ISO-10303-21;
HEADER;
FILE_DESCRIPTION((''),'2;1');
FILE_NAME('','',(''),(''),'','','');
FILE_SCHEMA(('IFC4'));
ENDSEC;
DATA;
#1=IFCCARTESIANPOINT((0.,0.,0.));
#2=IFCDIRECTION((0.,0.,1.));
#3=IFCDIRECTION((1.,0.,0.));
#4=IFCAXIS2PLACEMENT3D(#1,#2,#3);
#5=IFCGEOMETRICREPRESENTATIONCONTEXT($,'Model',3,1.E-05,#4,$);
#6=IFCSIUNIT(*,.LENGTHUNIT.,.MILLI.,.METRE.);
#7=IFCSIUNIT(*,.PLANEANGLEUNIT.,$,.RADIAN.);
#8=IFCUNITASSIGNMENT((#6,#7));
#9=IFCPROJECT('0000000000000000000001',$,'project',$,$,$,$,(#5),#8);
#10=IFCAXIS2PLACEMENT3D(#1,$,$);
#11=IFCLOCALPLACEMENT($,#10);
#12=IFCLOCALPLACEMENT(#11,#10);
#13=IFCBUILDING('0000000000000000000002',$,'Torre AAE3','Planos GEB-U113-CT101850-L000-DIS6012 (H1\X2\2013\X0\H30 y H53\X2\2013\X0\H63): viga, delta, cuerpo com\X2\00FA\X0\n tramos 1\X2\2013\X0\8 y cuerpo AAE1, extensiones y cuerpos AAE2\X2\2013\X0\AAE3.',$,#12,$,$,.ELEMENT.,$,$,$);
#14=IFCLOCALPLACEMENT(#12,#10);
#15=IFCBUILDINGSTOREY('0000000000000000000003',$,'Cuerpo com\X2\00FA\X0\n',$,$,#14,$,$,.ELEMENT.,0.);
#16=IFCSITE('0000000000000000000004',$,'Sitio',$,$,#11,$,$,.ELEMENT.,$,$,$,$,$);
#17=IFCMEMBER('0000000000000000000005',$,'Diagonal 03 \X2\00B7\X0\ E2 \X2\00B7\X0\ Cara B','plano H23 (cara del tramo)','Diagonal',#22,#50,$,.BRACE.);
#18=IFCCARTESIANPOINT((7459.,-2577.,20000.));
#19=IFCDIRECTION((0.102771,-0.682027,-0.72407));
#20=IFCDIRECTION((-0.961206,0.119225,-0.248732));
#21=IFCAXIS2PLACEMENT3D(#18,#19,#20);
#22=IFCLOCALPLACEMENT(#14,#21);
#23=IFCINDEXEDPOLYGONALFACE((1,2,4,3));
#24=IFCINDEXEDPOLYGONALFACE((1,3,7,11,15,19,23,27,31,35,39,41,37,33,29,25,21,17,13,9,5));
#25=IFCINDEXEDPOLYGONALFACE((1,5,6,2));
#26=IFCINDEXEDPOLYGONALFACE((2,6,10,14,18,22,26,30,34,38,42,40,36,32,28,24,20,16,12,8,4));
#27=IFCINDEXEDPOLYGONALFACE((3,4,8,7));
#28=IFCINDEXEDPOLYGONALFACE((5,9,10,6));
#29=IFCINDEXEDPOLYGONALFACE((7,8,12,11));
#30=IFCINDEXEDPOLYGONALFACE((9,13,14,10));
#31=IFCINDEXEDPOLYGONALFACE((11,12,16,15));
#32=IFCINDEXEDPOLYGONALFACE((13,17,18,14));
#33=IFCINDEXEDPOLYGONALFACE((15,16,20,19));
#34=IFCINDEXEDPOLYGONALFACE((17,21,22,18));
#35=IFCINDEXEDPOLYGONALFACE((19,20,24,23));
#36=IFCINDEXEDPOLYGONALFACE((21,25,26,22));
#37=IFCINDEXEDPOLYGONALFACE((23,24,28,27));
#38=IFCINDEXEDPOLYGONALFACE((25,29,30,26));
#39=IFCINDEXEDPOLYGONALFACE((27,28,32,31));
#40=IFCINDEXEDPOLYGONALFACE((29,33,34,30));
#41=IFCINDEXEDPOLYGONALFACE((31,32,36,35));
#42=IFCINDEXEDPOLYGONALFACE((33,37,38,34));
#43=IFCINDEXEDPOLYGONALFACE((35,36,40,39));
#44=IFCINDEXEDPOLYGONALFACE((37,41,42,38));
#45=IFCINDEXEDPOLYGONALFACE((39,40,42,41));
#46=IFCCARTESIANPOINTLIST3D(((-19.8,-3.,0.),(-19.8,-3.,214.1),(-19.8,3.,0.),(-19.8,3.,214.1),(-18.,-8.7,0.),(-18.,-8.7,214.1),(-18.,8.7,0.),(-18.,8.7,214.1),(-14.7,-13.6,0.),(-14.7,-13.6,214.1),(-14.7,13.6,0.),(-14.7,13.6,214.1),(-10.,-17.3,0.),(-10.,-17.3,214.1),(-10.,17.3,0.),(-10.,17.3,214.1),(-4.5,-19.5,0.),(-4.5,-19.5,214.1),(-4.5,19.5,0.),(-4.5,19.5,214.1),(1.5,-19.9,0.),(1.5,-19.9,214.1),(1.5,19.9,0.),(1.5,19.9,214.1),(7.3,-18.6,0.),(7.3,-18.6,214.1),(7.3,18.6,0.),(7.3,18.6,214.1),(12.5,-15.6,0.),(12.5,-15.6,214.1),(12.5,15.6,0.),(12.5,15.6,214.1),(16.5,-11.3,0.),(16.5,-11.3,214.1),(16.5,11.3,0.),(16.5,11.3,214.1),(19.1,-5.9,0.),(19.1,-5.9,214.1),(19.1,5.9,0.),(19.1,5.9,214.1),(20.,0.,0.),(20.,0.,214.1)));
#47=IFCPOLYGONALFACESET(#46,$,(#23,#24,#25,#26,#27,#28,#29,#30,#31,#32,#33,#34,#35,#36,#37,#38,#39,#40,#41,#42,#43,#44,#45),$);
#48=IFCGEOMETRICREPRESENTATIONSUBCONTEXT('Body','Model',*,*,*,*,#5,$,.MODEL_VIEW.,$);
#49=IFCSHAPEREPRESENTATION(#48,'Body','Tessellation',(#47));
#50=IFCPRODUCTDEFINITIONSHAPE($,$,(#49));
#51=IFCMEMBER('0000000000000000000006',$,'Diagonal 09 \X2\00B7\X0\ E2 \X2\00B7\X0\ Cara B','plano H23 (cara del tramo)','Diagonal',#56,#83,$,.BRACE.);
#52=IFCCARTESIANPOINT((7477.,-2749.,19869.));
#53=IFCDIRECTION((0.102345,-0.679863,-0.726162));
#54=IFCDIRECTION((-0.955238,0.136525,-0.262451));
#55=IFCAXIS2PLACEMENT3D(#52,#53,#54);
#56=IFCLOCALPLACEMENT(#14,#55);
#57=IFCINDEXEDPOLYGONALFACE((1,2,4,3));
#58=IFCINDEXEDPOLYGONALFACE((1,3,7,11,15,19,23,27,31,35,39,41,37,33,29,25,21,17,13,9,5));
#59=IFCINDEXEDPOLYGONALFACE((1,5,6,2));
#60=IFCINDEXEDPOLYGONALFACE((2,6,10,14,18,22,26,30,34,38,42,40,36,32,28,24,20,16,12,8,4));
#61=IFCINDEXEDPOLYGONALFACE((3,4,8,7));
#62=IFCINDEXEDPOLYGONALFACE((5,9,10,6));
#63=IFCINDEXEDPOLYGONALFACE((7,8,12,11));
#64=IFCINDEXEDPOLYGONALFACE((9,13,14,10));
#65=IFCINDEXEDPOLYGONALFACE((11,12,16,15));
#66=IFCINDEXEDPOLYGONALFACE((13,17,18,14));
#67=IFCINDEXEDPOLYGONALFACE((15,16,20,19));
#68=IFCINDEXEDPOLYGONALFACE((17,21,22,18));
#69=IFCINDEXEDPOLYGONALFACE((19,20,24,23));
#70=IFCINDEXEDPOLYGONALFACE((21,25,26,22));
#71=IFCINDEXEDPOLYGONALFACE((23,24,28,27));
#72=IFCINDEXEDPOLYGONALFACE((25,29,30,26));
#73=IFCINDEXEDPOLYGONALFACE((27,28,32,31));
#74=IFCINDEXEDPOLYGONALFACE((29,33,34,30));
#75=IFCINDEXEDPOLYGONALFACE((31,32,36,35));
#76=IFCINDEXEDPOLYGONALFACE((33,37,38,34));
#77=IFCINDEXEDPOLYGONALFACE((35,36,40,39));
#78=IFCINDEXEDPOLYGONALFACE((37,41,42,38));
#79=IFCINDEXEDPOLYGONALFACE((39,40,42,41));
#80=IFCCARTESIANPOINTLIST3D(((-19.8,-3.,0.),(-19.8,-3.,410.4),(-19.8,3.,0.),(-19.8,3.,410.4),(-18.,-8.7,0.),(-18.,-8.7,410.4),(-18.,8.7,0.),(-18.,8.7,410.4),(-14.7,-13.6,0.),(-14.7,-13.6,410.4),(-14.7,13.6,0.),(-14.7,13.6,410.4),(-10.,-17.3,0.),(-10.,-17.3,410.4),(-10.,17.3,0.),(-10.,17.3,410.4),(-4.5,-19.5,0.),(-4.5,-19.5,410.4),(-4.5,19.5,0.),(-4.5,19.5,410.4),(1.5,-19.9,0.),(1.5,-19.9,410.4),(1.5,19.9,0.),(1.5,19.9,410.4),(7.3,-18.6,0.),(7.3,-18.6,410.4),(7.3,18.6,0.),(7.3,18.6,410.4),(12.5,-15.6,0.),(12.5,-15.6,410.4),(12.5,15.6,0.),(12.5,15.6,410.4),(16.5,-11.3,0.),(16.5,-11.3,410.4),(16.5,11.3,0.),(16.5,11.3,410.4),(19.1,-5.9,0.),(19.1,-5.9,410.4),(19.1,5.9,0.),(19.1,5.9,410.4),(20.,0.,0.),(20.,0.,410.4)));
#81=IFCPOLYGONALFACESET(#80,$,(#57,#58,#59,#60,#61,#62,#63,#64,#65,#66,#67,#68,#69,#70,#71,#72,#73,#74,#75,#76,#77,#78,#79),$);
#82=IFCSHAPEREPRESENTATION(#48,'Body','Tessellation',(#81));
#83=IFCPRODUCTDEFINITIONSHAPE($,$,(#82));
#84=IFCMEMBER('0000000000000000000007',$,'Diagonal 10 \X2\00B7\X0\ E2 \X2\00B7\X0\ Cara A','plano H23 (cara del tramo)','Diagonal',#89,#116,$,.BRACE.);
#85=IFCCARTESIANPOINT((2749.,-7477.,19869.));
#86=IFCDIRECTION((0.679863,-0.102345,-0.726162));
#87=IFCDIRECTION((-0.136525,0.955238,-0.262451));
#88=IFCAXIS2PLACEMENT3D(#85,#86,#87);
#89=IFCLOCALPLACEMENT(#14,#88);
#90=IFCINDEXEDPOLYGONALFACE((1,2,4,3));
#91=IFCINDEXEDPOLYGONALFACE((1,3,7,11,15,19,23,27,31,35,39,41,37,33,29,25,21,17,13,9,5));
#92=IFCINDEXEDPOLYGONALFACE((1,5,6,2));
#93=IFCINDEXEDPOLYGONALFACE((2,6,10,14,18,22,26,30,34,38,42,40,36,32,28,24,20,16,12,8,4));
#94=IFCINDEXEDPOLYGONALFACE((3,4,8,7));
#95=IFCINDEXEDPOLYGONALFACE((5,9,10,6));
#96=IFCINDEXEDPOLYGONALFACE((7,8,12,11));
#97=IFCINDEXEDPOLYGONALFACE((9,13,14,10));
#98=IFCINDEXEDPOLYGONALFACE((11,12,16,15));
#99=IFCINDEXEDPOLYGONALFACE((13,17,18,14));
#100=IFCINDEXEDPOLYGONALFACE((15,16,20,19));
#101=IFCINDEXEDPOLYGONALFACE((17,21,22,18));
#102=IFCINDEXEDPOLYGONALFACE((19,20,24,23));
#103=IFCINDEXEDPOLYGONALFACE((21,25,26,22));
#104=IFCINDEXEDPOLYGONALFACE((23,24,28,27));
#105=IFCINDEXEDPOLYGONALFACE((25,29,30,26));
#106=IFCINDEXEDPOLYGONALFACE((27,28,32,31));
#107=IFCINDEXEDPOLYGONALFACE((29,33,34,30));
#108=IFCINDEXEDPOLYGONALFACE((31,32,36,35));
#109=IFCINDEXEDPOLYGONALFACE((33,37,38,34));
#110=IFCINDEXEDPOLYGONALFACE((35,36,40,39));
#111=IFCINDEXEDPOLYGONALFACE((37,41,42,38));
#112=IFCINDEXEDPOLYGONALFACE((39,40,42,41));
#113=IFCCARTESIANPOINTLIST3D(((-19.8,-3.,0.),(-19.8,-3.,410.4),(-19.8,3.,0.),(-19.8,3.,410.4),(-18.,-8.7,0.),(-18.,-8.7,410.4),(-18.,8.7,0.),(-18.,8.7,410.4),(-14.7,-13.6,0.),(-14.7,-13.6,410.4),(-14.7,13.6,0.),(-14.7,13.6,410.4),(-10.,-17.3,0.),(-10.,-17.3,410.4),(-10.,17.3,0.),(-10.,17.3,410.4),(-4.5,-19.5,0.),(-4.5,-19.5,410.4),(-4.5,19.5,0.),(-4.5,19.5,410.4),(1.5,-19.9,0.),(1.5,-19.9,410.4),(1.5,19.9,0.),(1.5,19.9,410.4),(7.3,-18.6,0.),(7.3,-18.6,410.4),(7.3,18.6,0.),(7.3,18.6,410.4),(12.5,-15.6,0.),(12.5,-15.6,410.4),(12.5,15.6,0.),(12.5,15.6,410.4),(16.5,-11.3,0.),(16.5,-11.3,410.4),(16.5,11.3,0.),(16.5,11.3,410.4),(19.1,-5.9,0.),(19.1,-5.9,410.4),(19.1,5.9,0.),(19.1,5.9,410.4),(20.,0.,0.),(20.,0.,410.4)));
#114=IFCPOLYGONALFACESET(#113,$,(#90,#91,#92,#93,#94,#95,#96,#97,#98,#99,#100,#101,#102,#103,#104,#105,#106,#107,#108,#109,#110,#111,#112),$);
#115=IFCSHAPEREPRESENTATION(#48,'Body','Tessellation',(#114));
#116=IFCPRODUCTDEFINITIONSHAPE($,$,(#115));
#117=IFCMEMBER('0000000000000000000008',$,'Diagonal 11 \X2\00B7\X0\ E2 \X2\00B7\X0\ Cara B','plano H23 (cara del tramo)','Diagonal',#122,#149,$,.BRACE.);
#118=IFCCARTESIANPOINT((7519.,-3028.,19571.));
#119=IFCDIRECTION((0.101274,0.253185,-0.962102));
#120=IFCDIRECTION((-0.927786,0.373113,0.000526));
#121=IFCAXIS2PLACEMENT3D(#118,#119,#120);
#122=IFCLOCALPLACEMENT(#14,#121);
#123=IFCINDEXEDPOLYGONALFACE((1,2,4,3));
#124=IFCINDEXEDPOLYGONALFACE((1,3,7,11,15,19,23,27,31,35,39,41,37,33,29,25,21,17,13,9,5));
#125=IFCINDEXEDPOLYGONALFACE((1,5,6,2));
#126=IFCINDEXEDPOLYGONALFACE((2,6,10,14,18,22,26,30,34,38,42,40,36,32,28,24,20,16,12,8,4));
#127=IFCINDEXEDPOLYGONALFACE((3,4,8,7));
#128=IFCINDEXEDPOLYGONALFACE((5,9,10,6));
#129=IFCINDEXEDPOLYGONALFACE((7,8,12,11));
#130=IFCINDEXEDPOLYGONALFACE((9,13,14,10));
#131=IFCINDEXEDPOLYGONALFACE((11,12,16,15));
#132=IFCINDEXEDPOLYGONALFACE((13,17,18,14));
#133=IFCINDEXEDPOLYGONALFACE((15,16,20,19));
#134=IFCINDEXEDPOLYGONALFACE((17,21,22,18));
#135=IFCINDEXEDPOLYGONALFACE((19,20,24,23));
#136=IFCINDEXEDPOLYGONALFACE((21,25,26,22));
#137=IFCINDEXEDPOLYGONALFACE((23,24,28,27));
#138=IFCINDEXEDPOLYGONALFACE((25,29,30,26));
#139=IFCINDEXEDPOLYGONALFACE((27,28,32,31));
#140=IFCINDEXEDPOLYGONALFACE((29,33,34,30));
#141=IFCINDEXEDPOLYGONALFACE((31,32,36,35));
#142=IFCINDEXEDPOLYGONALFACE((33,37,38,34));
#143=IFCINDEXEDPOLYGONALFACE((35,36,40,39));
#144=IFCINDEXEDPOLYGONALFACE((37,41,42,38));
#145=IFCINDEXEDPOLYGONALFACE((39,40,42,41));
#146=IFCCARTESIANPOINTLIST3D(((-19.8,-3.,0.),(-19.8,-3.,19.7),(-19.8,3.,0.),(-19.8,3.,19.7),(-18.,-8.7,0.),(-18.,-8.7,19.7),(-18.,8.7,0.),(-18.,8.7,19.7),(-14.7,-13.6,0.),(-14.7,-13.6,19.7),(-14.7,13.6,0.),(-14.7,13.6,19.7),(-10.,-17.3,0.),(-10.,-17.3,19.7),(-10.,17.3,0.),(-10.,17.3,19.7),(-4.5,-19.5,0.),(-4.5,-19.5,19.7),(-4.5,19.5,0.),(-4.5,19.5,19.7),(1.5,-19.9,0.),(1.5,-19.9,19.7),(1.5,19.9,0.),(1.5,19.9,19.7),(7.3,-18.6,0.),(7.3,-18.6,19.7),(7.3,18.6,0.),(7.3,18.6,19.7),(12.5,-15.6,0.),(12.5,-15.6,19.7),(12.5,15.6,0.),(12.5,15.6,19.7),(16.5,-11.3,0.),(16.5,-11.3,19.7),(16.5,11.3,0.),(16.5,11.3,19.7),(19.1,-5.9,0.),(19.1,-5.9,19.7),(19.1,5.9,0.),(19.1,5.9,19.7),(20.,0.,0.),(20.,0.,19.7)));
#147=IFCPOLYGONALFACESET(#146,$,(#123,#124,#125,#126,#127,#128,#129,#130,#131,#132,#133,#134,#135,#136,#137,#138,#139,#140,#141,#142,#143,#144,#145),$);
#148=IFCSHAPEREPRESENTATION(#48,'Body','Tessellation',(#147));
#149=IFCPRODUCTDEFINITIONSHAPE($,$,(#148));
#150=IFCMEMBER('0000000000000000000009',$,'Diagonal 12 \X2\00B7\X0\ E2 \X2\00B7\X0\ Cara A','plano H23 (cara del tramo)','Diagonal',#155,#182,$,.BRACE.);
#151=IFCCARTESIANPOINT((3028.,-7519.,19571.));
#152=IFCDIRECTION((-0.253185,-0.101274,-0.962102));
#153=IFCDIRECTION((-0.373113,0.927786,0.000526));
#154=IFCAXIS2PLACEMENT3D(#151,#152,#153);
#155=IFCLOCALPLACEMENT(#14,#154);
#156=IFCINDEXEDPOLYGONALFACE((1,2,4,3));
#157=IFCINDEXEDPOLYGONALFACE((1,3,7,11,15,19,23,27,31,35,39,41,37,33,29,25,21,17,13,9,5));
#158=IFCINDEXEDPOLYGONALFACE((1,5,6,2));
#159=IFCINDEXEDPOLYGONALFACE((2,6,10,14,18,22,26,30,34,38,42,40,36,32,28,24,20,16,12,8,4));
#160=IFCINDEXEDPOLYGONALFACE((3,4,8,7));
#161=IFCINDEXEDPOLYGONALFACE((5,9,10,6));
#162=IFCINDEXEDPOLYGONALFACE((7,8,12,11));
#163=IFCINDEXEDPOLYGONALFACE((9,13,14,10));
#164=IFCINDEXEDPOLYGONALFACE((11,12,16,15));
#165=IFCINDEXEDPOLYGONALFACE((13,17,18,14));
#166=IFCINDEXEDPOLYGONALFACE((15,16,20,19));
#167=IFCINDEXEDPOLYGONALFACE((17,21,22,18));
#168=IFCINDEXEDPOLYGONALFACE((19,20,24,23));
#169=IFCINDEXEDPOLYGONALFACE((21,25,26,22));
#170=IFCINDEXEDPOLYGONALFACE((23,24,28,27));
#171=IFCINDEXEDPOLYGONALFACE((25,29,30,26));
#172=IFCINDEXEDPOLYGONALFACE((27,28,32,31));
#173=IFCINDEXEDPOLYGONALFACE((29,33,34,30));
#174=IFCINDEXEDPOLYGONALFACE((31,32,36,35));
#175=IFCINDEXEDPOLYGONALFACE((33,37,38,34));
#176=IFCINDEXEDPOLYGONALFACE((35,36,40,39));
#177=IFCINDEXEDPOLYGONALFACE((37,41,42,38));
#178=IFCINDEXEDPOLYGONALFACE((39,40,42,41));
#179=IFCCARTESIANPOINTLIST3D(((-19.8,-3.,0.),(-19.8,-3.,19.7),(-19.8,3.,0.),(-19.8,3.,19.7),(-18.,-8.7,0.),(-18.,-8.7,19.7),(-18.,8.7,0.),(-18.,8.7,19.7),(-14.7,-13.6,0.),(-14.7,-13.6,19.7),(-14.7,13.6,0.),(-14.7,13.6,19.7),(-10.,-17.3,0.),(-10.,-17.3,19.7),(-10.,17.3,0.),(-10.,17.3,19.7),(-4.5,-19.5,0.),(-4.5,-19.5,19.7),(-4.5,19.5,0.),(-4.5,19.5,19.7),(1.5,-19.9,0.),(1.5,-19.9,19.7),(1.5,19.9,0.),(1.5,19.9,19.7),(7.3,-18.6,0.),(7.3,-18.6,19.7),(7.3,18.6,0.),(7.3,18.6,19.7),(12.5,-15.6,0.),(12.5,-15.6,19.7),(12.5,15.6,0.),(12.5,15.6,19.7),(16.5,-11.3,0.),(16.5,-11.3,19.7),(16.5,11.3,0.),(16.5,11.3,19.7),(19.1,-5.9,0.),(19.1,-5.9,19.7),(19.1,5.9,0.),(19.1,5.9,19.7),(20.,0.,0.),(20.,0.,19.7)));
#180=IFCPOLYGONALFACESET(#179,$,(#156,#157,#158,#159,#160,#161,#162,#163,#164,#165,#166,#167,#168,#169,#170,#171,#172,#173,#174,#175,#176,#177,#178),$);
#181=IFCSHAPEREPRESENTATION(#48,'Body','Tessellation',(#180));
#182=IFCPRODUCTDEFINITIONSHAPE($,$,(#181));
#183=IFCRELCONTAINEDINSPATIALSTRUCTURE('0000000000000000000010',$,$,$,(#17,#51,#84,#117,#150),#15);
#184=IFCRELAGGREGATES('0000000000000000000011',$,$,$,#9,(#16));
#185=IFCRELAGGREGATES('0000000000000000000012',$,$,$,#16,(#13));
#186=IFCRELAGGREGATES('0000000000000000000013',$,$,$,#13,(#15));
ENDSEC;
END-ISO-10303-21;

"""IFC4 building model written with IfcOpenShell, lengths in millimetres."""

from ifc_helpers import new_model, si_unit, frame, origin, origin_with_axes, place, context, subcontext, project, spatial, circle, extrude, element, save


model = new_model("IFC4")

# Units and contexts
model_context = context("Model", 3, precision=1e-05, world=origin_with_axes())
body_context = subcontext(model_context, "Body", "Model", "MODEL_VIEW")
ifc_project = project(units=[si_unit("LENGTHUNIT", "METRE", prefix="MILLI"), si_unit("PLANEANGLEUNIT", "RADIAN")], contexts=[model_context])

# Site, building, storey
site_placement = place(None, origin())
site = spatial("IfcSite", under=ifc_project, at=site_placement, Name="Sitio", CompositionType="ELEMENT")
building_placement = place(site_placement, origin())
building = spatial("IfcBuilding", under=site, at=building_placement, Name="Torre AAE3", Description="Planos GEB-U113-CT101850-L000-DIS6012 (H1–H30 y H53–H63): viga, delta, cuerpo común tramos 1–8 y cuerpo AAE1, extensiones y cuerpos AAE2–AAE3.", CompositionType="ELEMENT")
storey_placement = place(building_placement, origin())
storey = spatial("IfcBuildingStorey", under=building, at=storey_placement, Name="Cuerpo común", CompositionType="ELEMENT", Elevation=0.0)

# Members
member_1_placement = place(storey_placement, frame((7459.0, -2577.0, 20000.0), z_axis=(0.102771, -0.682027, -0.72407), x_axis=(-0.961206, 0.119225, -0.248732)))
element("IfcMember", 1, at=member_1_placement, inside=storey, Name="Diagonal 03 · E2 · Cara B", Description="plano H23 (cara del tramo)", ObjectType="Diagonal", PredefinedType="BRACE", context=body_context, shape_type="SweptSolid", body=[
    extrude(circle(Radius=20.0), None, (0.0, 0.0, 1.0), 214.1),
])
for number, where, z_axis, x_axis, name in (
    (2, (7477.0, -2749.0, 19869.0), (0.102345, -0.679863, -0.726162), (-0.955238, 0.136525, -0.262451), "Diagonal 09 · E2 · Cara B"),
    (3, (2749.0, -7477.0, 19869.0), (0.679863, -0.102345, -0.726162), (-0.136525, 0.955238, -0.262451), "Diagonal 10 · E2 · Cara A"),
):
    element("IfcMember", number, at=place(storey_placement, frame(where, z_axis=z_axis, x_axis=x_axis)), inside=storey, Name=name, Description="plano H23 (cara del tramo)", ObjectType="Diagonal", PredefinedType="BRACE", context=body_context, shape_type="SweptSolid", body=[
        extrude(circle(Radius=20.0), None, (0.0, 0.0, 1.0), 410.4),
    ])
for number, where, z_axis, x_axis, name in (
    (4, (7519.0, -3028.0, 19571.0), (0.101274, 0.253185, -0.962102), (-0.927786, 0.373113, 0.000526), "Diagonal 11 · E2 · Cara B"),
    (5, (3028.0, -7519.0, 19571.0), (-0.253185, -0.101274, -0.962102), (-0.373113, 0.927786, 0.000526), "Diagonal 12 · E2 · Cara A"),
):
    element("IfcMember", number, at=place(storey_placement, frame(where, z_axis=z_axis, x_axis=x_axis)), inside=storey, Name=name, Description="plano H23 (cara del tramo)", ObjectType="Diagonal", PredefinedType="BRACE", context=body_context, shape_type="SweptSolid", body=[
        extrude(circle(Radius=20.0), None, (0.0, 0.0, 1.0), 19.7),
    ])

save(model, "model.ifc")
